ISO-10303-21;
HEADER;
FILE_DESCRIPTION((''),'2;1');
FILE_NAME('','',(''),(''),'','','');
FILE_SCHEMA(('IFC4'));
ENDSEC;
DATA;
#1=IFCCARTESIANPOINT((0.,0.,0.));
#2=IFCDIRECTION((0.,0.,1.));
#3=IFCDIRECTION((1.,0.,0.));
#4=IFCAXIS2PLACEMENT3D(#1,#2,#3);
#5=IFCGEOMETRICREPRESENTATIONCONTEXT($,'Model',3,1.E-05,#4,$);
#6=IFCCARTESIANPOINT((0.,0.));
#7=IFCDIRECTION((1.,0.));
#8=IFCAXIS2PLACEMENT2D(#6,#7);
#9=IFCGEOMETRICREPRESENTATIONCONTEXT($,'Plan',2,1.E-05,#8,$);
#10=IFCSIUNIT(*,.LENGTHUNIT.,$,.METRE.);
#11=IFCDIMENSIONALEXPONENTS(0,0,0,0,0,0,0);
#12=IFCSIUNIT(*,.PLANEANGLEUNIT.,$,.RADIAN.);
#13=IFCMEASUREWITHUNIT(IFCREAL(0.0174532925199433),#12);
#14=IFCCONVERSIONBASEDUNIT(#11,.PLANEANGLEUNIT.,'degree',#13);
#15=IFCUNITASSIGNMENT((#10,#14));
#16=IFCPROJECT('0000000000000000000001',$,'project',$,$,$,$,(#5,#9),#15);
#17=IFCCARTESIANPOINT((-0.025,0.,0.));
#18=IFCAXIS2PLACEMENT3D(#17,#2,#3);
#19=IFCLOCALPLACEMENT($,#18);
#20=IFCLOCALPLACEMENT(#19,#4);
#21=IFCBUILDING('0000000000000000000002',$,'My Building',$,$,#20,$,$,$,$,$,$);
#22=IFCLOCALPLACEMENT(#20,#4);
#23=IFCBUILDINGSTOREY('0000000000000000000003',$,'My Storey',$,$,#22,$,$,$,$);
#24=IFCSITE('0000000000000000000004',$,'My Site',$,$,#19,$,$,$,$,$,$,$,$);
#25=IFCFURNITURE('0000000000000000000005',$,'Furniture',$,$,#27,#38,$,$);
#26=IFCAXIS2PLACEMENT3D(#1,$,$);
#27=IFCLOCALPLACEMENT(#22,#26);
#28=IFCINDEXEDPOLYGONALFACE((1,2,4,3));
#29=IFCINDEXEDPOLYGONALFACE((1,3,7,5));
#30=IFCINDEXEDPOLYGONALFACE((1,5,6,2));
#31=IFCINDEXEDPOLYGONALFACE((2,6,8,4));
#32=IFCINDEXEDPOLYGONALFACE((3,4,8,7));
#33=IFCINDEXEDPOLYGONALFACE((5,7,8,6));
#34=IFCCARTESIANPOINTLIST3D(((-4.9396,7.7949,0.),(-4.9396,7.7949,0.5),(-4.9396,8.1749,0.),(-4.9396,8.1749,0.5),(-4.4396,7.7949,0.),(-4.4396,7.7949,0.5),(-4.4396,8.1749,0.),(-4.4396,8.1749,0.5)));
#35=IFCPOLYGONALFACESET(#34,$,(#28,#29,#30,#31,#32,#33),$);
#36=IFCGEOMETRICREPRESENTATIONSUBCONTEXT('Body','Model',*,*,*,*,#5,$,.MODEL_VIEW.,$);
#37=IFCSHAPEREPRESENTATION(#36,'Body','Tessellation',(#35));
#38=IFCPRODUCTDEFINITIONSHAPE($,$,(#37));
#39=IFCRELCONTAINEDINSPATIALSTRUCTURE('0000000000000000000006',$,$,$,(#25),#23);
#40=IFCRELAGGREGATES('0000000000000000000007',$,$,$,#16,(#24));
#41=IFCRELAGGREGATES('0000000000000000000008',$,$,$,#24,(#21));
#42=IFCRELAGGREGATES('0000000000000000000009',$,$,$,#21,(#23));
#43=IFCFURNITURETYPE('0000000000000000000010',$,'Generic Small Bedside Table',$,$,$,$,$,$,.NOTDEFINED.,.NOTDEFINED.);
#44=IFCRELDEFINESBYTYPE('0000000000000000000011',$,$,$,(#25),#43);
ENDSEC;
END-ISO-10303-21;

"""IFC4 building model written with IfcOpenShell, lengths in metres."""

from ifc_helpers import new_model, entity, si_unit, converted_unit, frame, origin_with_axes, origin_2d_with_axis, place, context, subcontext, project, spatial, line, indexed_curve, outline, extrude, shape, source, transform, mapped, type_object, type_shapes, element, save


model = new_model("IFC4")

# Units and contexts
model_context = context("Model", 3, precision=1e-05, world=origin_with_axes())
plan_context = context("Plan", 2, precision=1e-05, world=origin_2d_with_axis())
body_context_1 = subcontext(model_context, "Body", "Model", "MODEL_VIEW")
body_context_2 = subcontext(plan_context, "Body", "Plan", "PLAN_VIEW")
ifc_project = project(units=[si_unit("LENGTHUNIT", "METRE"), converted_unit("PLANEANGLEUNIT", "degree", entity("IfcReal", 0.0174532925199433), si_unit("PLANEANGLEUNIT", "RADIAN"), dimensions=[0, 0, 0, 0, 0, 0, 0])], contexts=[model_context, plan_context])

# Site, building, storey
site_placement = place(None, frame((-0.025, 0.0, 0.0), z_axis=(0.0, 0.0, 1.0), x_axis=(1.0, 0.0, 0.0)))
site = spatial("IfcSite", under=ifc_project, at=site_placement, Name="My Site")
building_placement = place(site_placement, origin_with_axes())
building = spatial("IfcBuilding", under=site, at=building_placement, Name="My Building")
storey_placement = place(building_placement, origin_with_axes())
storey = spatial("IfcBuildingStorey", under=building, at=storey_placement, Name="My Storey")

# Furniture
furniture_type_1 = type_object("IfcFurnitureType", Name="Generic Small Bedside Table", AssemblyPlace="NOTDEFINED", PredefinedType="NOTDEFINED")
shared_shape_1 = source(origin_with_axes(), body_context_1, "Body", "SweptSolid", [
    extrude(outline(indexed_curve([(0.0, 0.0), (0.5, 0.0), (0.5, 0.38), (0.0, 0.38)], segments=[line(1, 2, 3, 4, 1)])), frame((-0.25, -0.19, 0.0), z_axis=(0.0, 0.0, 1.0), x_axis=(1.0, 0.0, 0.0)), (0.0, 0.0, 1.0), 0.5),
])
shared_shape_2 = source(origin_with_axes(), body_context_2, "Body", "Curve2D", [
    entity("IfcIndexedPolyCurve", entity("IfcCartesianPointList2D", [[-0.25, -0.19], [0.25, -0.19], [0.25, 0.19], [-0.25, 0.19]]), [entity("IfcLineIndex", [1, 2, 3, 4, 1])]),
])
type_shapes(furniture_type_1, [shared_shape_1, shared_shape_2])
for number, where, z_axis, x_axis, name in (
    (1, (-4.6896, 7.9849, 0.0), (0.0, 0.0, 1.0), (1.0, 0.0, 0.0), "Furniture"),
):
    element("IfcFurniture", number, at=place(storey_placement, frame(where, z_axis=z_axis, x_axis=x_axis)), inside=storey, type_object=furniture_type_1, Name=name, shapes=[
        shape(body_context_1, "Body", "MappedRepresentation", [mapped(shared_shape_1, transform((0.0, 0.0, 0.0), x_axis=(1.0, 0.0, 0.0), y_axis=(0.0, 1.0, 0.0), z_axis=(0.0, 0.0, 1.0), scale=1.0))]),
        shape(body_context_2, "Body", "MappedRepresentation", [mapped(shared_shape_2, transform((0.0, 0.0, 0.0), x_axis=(1.0, 0.0, 0.0), y_axis=(0.0, 1.0, 0.0), z_axis=(0.0, 0.0, 1.0), scale=1.0))]),
    ])

save(model, "model.ifc")
